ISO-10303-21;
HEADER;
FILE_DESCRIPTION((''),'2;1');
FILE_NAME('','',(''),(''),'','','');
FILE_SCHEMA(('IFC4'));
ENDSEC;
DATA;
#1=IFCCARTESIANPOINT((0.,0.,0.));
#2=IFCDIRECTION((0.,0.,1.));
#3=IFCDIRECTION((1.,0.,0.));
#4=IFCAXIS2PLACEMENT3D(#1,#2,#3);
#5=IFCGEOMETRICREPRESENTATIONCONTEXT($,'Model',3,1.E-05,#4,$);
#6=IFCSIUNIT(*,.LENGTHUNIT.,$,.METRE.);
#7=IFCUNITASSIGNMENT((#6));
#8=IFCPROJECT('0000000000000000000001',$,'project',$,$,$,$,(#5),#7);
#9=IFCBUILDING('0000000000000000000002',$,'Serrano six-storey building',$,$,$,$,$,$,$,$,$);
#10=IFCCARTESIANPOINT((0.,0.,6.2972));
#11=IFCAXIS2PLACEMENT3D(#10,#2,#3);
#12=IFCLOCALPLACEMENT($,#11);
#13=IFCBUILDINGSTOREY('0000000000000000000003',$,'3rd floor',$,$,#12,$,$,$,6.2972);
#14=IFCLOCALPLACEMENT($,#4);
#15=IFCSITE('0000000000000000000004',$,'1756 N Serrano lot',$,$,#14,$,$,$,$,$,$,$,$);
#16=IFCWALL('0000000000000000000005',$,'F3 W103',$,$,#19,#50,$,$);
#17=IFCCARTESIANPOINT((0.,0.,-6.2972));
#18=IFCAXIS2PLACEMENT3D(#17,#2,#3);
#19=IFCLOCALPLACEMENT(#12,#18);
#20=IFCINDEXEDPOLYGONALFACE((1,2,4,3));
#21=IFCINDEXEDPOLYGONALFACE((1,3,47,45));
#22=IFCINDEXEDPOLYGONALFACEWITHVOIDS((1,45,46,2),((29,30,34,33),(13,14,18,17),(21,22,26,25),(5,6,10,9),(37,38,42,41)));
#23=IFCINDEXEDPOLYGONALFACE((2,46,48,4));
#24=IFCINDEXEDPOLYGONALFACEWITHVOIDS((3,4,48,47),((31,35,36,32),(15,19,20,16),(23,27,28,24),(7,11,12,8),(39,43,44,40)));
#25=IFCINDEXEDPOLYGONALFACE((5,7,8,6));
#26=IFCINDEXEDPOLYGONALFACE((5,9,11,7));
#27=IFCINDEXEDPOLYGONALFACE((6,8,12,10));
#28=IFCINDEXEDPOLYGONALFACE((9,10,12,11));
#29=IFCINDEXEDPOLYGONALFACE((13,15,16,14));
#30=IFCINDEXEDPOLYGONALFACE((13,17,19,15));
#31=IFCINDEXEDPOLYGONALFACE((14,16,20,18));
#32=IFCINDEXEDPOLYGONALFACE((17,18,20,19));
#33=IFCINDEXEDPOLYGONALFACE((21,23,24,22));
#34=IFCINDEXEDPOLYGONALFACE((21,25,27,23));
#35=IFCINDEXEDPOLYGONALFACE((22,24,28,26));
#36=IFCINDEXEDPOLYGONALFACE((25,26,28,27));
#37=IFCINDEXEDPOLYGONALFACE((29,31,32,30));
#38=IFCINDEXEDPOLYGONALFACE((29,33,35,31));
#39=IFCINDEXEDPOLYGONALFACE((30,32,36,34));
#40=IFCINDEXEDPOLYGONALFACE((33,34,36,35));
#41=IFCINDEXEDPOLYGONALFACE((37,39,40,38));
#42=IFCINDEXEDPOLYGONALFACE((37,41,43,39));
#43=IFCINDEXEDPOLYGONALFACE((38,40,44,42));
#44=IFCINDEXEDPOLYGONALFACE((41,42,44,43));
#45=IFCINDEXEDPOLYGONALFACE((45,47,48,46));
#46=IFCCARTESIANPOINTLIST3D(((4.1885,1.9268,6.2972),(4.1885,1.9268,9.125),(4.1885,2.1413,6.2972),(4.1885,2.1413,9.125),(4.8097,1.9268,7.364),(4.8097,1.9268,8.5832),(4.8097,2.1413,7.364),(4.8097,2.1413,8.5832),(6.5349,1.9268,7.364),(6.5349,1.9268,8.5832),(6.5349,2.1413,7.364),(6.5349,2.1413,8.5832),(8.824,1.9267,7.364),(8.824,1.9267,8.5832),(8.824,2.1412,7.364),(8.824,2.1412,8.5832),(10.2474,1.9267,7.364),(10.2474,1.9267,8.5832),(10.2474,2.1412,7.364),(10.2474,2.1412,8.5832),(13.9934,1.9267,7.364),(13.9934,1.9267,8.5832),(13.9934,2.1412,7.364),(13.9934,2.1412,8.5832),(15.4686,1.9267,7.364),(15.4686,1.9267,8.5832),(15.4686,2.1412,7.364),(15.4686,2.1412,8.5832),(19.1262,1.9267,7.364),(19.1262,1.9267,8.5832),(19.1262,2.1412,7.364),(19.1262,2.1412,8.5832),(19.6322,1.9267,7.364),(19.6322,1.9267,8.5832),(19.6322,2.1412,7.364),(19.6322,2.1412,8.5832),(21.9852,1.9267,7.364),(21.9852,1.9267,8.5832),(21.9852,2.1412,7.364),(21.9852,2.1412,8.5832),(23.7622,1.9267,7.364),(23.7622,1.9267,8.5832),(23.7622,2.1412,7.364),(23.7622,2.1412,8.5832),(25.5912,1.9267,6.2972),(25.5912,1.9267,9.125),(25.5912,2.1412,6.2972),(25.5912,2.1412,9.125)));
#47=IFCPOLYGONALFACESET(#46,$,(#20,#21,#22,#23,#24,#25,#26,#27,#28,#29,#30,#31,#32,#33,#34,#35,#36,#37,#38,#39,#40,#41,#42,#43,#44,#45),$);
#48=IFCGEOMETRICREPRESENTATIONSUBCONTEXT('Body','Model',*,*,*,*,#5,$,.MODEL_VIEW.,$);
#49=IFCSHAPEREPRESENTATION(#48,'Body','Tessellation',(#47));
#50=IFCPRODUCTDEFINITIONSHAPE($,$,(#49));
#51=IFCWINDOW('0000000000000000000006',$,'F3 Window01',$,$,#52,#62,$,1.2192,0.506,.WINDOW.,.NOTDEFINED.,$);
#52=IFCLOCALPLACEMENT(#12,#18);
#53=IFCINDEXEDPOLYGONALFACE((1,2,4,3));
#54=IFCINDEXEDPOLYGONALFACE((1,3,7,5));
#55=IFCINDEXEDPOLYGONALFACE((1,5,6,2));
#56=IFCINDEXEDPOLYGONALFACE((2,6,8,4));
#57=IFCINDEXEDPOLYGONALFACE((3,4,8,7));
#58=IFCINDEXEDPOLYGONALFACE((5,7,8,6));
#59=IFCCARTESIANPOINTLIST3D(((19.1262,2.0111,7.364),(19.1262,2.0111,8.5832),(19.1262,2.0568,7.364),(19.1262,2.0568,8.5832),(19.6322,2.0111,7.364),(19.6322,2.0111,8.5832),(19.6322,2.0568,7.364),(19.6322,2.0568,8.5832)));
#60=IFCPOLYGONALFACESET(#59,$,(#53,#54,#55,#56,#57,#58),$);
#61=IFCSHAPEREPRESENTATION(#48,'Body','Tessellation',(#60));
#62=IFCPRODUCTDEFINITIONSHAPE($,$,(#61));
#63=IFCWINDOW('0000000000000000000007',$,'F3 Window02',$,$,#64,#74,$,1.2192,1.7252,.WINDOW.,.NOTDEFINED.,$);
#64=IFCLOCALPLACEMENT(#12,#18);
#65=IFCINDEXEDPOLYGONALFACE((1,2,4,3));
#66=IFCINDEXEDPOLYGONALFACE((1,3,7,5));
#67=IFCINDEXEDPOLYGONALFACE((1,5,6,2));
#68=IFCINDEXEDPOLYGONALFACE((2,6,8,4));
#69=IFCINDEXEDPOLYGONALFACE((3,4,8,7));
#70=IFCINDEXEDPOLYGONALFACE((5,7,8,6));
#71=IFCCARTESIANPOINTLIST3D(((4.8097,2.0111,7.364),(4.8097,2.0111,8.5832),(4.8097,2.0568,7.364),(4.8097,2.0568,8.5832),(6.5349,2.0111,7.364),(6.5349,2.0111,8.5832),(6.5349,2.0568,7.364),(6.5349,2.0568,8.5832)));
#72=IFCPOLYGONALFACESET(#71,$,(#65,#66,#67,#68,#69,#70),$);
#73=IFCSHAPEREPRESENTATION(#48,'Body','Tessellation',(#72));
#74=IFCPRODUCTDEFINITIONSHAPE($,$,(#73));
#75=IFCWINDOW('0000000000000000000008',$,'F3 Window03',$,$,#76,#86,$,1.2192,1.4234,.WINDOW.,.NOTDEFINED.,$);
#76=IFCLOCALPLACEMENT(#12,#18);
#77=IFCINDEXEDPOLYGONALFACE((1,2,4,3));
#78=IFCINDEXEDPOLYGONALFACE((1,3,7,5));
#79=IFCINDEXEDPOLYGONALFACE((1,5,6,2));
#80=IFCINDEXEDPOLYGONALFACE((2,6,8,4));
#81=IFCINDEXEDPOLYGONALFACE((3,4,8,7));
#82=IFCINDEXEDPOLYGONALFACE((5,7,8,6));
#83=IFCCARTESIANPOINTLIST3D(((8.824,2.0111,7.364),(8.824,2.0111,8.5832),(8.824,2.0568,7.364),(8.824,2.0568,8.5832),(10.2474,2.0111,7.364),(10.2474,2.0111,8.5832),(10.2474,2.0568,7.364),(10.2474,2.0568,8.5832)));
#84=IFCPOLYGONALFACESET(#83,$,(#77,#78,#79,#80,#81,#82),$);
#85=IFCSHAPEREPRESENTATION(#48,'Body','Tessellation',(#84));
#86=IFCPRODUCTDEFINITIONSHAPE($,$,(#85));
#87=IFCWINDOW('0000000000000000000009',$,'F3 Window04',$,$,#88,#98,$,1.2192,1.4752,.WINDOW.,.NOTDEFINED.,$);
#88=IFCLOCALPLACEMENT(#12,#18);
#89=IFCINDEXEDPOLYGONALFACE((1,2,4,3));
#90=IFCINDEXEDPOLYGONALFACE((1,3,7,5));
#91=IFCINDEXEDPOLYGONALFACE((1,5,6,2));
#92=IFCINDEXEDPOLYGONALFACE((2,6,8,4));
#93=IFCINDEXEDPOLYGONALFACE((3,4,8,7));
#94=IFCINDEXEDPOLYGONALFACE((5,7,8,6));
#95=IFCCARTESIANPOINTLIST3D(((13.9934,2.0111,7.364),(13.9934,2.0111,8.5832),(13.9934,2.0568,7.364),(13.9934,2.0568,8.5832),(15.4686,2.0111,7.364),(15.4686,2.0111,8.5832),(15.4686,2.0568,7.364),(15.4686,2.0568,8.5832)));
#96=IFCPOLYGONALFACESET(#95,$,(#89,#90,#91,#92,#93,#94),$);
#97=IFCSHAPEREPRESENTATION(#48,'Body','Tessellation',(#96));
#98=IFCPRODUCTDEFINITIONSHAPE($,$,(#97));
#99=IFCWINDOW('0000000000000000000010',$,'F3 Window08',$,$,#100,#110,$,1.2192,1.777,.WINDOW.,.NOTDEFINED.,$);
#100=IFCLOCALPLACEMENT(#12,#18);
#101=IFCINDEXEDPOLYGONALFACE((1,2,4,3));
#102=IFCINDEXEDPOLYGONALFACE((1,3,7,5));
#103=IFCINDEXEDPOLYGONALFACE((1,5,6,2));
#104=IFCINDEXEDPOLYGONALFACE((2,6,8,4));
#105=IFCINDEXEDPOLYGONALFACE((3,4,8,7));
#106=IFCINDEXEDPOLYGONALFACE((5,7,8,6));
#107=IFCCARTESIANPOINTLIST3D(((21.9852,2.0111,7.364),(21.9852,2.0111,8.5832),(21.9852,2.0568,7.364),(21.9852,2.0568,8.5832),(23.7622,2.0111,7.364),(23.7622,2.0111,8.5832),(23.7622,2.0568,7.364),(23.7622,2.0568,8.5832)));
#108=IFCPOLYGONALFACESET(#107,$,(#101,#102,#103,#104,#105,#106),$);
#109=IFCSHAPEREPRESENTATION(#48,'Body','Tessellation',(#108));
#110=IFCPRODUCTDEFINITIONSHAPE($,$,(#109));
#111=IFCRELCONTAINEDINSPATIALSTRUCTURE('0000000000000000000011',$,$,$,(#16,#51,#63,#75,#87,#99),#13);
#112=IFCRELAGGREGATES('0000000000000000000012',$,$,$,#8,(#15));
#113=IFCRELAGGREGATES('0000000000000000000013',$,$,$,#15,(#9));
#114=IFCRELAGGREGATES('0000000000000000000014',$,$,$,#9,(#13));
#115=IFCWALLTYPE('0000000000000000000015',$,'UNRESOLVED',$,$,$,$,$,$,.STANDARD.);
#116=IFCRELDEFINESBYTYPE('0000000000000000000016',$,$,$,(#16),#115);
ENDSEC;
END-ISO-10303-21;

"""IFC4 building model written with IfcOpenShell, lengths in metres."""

from ifc_helpers import new_model, si_unit, frame, origin_with_axes, place, context, subcontext, project, spatial, polyline, outline, extrude, type_object, element, fill, save


model = new_model("IFC4")

# Units and contexts
model_context = context("Model", 3, precision=1e-05, world=origin_with_axes())
body_context = subcontext(model_context, "Body", "Model", "MODEL_VIEW")
ifc_project = project(units=[si_unit("LENGTHUNIT", "METRE")], contexts=[model_context])

# Site, building, storey
site_placement = place(None, origin_with_axes())
site = spatial("IfcSite", under=ifc_project, at=site_placement, Name="1756 N Serrano lot")
building = spatial("IfcBuilding", under=site, Name="Serrano six-storey building")
storey_placement = place(None, frame((0.0, 0.0, 6.2972), z_axis=(0.0, 0.0, 1.0), x_axis=(1.0, 0.0, 0.0)))
storey = spatial("IfcBuildingStorey", under=building, at=storey_placement, Name="3rd floor", Elevation=6.2972)

# Wall, openings, windows
wall_type = type_object("IfcWallType", Name="UNRESOLVED", PredefinedType="STANDARD")
wall_1_placement = place(storey_placement, frame((0.0, 0.0, -6.2972), z_axis=(0.0, 0.0, 1.0), x_axis=(1.0, 0.0, 0.0)))
wall_1 = element("IfcWall", 1, at=wall_1_placement, inside=storey, type_object=wall_type, Name="F3 W103", context=body_context, shape_type="SweptSolid", body=[
    extrude(outline(polyline([(4.1885, 1.9268), (4.1885, 2.1413), (25.5912, 2.1412), (25.5912, 1.9267), (4.1885, 1.9268)])), frame((0.0, 0.0, 6.2972)), (0.0, 0.0, 1.0), 2.8278),
])
opening_1_placement = place(None, origin_with_axes())
opening_1 = element("IfcOpeningElement", 2, at=opening_1_placement, cuts=wall_1, PredefinedType="OPENING", context=body_context, shape_type="SweptSolid", body=[
    extrude(outline(polyline([(19.6322, 2.1595), (19.6322, 1.9084), (19.1262, 1.9084), (19.1262, 2.1595), (19.6322, 2.1595)])), frame((0.0, 0.0, 7.364)), (0.0, 0.0, 1.0), 1.2192),
])
opening_2_placement = place(None, origin_with_axes())
opening_2 = element("IfcOpeningElement", 3, at=opening_2_placement, cuts=wall_1, PredefinedType="OPENING", context=body_context, shape_type="SweptSolid", body=[
    extrude(outline(polyline([(6.5349, 2.1595), (6.5349, 1.9084), (4.8097, 1.9084), (4.8097, 2.1595), (6.5349, 2.1595)])), frame((0.0, 0.0, 7.364)), (0.0, 0.0, 1.0), 1.2192),
])
opening_3_placement = place(None, origin_with_axes())
opening_3 = element("IfcOpeningElement", 4, at=opening_3_placement, cuts=wall_1, PredefinedType="OPENING", context=body_context, shape_type="SweptSolid", body=[
    extrude(outline(polyline([(10.2474, 2.1595), (10.2474, 1.9084), (8.824, 1.9084), (8.824, 2.1595), (10.2474, 2.1595)])), frame((0.0, 0.0, 7.364)), (0.0, 0.0, 1.0), 1.2192),
])
opening_4_placement = place(None, origin_with_axes())
opening_4 = element("IfcOpeningElement", 5, at=opening_4_placement, cuts=wall_1, PredefinedType="OPENING", context=body_context, shape_type="SweptSolid", body=[
    extrude(outline(polyline([(15.4686, 2.1595), (15.4686, 1.9084), (13.9934, 1.9084), (13.9934, 2.1595), (15.4686, 2.1595)])), frame((0.0, 0.0, 7.364)), (0.0, 0.0, 1.0), 1.2192),
])
opening_5_placement = place(None, origin_with_axes())
opening_5 = element("IfcOpeningElement", 6, at=opening_5_placement, cuts=wall_1, PredefinedType="OPENING", context=body_context, shape_type="SweptSolid", body=[
    extrude(outline(polyline([(23.7622, 2.1595), (23.7622, 1.9084), (21.9852, 1.9084), (21.9852, 2.1595), (23.7622, 2.1595)])), frame((0.0, 0.0, 7.364)), (0.0, 0.0, 1.0), 1.2192),
])
window_1_placement = place(storey_placement, frame((0.0, 0.0, -6.2972), z_axis=(0.0, 0.0, 1.0), x_axis=(1.0, 0.0, 0.0)))
window_1 = element("IfcWindow", 7, at=window_1_placement, inside=storey, Name="F3 Window01", OverallHeight=1.2192, OverallWidth=0.506, PartitioningType="NOTDEFINED", PredefinedType="WINDOW", context=body_context, shape_type="SweptSolid", body=[
    extrude(outline(polyline([(19.6322, 2.0568), (19.6322, 2.0111), (19.1262, 2.0111), (19.1262, 2.0568), (19.6322, 2.0568)])), frame((0.0, 0.0, 7.364)), (0.0, 0.0, 1.0), 1.2192),
])
fill(opening_1, window_1)
window_2_placement = place(storey_placement, frame((0.0, 0.0, -6.2972), z_axis=(0.0, 0.0, 1.0), x_axis=(1.0, 0.0, 0.0)))
window_2 = element("IfcWindow", 8, at=window_2_placement, inside=storey, Name="F3 Window02", OverallHeight=1.2192, OverallWidth=1.7252, PartitioningType="NOTDEFINED", PredefinedType="WINDOW", context=body_context, shape_type="SweptSolid", body=[
    extrude(outline(polyline([(6.5349, 2.0568), (6.5349, 2.0111), (4.8097, 2.0111), (4.8097, 2.0568), (6.5349, 2.0568)])), frame((0.0, 0.0, 7.364)), (0.0, 0.0, 1.0), 1.2192),
])
fill(opening_2, window_2)
window_3_placement = place(storey_placement, frame((0.0, 0.0, -6.2972), z_axis=(0.0, 0.0, 1.0), x_axis=(1.0, 0.0, 0.0)))
window_3 = element("IfcWindow", 9, at=window_3_placement, inside=storey, Name="F3 Window03", OverallHeight=1.2192, OverallWidth=1.4234, PartitioningType="NOTDEFINED", PredefinedType="WINDOW", context=body_context, shape_type="SweptSolid", body=[
    extrude(outline(polyline([(10.2474, 2.0568), (10.2474, 2.0111), (8.824, 2.0111), (8.824, 2.0568), (10.2474, 2.0568)])), frame((0.0, 0.0, 7.364)), (0.0, 0.0, 1.0), 1.2192),
])
fill(opening_3, window_3)
window_4_placement = place(storey_placement, frame((0.0, 0.0, -6.2972), z_axis=(0.0, 0.0, 1.0), x_axis=(1.0, 0.0, 0.0)))
window_4 = element("IfcWindow", 10, at=window_4_placement, inside=storey, Name="F3 Window04", OverallHeight=1.2192, OverallWidth=1.4752, PartitioningType="NOTDEFINED", PredefinedType="WINDOW", context=body_context, shape_type="SweptSolid", body=[
    extrude(outline(polyline([(15.4686, 2.0568), (15.4686, 2.0111), (13.9934, 2.0111), (13.9934, 2.0568), (15.4686, 2.0568)])), frame((0.0, 0.0, 7.364)), (0.0, 0.0, 1.0), 1.2192),
])
fill(opening_4, window_4)
window_5_placement = place(storey_placement, frame((0.0, 0.0, -6.2972), z_axis=(0.0, 0.0, 1.0), x_axis=(1.0, 0.0, 0.0)))
window_5 = element("IfcWindow", 11, at=window_5_placement, inside=storey, Name="F3 Window08", OverallHeight=1.2192, OverallWidth=1.777, PartitioningType="NOTDEFINED", PredefinedType="WINDOW", context=body_context, shape_type="SweptSolid", body=[
    extrude(outline(polyline([(23.7622, 2.0568), (23.7622, 2.0111), (21.9852, 2.0111), (21.9852, 2.0568), (23.7622, 2.0568)])), frame((0.0, 0.0, 7.364)), (0.0, 0.0, 1.0), 1.2192),
])
fill(opening_5, window_5)

save(model, "model.ifc")
